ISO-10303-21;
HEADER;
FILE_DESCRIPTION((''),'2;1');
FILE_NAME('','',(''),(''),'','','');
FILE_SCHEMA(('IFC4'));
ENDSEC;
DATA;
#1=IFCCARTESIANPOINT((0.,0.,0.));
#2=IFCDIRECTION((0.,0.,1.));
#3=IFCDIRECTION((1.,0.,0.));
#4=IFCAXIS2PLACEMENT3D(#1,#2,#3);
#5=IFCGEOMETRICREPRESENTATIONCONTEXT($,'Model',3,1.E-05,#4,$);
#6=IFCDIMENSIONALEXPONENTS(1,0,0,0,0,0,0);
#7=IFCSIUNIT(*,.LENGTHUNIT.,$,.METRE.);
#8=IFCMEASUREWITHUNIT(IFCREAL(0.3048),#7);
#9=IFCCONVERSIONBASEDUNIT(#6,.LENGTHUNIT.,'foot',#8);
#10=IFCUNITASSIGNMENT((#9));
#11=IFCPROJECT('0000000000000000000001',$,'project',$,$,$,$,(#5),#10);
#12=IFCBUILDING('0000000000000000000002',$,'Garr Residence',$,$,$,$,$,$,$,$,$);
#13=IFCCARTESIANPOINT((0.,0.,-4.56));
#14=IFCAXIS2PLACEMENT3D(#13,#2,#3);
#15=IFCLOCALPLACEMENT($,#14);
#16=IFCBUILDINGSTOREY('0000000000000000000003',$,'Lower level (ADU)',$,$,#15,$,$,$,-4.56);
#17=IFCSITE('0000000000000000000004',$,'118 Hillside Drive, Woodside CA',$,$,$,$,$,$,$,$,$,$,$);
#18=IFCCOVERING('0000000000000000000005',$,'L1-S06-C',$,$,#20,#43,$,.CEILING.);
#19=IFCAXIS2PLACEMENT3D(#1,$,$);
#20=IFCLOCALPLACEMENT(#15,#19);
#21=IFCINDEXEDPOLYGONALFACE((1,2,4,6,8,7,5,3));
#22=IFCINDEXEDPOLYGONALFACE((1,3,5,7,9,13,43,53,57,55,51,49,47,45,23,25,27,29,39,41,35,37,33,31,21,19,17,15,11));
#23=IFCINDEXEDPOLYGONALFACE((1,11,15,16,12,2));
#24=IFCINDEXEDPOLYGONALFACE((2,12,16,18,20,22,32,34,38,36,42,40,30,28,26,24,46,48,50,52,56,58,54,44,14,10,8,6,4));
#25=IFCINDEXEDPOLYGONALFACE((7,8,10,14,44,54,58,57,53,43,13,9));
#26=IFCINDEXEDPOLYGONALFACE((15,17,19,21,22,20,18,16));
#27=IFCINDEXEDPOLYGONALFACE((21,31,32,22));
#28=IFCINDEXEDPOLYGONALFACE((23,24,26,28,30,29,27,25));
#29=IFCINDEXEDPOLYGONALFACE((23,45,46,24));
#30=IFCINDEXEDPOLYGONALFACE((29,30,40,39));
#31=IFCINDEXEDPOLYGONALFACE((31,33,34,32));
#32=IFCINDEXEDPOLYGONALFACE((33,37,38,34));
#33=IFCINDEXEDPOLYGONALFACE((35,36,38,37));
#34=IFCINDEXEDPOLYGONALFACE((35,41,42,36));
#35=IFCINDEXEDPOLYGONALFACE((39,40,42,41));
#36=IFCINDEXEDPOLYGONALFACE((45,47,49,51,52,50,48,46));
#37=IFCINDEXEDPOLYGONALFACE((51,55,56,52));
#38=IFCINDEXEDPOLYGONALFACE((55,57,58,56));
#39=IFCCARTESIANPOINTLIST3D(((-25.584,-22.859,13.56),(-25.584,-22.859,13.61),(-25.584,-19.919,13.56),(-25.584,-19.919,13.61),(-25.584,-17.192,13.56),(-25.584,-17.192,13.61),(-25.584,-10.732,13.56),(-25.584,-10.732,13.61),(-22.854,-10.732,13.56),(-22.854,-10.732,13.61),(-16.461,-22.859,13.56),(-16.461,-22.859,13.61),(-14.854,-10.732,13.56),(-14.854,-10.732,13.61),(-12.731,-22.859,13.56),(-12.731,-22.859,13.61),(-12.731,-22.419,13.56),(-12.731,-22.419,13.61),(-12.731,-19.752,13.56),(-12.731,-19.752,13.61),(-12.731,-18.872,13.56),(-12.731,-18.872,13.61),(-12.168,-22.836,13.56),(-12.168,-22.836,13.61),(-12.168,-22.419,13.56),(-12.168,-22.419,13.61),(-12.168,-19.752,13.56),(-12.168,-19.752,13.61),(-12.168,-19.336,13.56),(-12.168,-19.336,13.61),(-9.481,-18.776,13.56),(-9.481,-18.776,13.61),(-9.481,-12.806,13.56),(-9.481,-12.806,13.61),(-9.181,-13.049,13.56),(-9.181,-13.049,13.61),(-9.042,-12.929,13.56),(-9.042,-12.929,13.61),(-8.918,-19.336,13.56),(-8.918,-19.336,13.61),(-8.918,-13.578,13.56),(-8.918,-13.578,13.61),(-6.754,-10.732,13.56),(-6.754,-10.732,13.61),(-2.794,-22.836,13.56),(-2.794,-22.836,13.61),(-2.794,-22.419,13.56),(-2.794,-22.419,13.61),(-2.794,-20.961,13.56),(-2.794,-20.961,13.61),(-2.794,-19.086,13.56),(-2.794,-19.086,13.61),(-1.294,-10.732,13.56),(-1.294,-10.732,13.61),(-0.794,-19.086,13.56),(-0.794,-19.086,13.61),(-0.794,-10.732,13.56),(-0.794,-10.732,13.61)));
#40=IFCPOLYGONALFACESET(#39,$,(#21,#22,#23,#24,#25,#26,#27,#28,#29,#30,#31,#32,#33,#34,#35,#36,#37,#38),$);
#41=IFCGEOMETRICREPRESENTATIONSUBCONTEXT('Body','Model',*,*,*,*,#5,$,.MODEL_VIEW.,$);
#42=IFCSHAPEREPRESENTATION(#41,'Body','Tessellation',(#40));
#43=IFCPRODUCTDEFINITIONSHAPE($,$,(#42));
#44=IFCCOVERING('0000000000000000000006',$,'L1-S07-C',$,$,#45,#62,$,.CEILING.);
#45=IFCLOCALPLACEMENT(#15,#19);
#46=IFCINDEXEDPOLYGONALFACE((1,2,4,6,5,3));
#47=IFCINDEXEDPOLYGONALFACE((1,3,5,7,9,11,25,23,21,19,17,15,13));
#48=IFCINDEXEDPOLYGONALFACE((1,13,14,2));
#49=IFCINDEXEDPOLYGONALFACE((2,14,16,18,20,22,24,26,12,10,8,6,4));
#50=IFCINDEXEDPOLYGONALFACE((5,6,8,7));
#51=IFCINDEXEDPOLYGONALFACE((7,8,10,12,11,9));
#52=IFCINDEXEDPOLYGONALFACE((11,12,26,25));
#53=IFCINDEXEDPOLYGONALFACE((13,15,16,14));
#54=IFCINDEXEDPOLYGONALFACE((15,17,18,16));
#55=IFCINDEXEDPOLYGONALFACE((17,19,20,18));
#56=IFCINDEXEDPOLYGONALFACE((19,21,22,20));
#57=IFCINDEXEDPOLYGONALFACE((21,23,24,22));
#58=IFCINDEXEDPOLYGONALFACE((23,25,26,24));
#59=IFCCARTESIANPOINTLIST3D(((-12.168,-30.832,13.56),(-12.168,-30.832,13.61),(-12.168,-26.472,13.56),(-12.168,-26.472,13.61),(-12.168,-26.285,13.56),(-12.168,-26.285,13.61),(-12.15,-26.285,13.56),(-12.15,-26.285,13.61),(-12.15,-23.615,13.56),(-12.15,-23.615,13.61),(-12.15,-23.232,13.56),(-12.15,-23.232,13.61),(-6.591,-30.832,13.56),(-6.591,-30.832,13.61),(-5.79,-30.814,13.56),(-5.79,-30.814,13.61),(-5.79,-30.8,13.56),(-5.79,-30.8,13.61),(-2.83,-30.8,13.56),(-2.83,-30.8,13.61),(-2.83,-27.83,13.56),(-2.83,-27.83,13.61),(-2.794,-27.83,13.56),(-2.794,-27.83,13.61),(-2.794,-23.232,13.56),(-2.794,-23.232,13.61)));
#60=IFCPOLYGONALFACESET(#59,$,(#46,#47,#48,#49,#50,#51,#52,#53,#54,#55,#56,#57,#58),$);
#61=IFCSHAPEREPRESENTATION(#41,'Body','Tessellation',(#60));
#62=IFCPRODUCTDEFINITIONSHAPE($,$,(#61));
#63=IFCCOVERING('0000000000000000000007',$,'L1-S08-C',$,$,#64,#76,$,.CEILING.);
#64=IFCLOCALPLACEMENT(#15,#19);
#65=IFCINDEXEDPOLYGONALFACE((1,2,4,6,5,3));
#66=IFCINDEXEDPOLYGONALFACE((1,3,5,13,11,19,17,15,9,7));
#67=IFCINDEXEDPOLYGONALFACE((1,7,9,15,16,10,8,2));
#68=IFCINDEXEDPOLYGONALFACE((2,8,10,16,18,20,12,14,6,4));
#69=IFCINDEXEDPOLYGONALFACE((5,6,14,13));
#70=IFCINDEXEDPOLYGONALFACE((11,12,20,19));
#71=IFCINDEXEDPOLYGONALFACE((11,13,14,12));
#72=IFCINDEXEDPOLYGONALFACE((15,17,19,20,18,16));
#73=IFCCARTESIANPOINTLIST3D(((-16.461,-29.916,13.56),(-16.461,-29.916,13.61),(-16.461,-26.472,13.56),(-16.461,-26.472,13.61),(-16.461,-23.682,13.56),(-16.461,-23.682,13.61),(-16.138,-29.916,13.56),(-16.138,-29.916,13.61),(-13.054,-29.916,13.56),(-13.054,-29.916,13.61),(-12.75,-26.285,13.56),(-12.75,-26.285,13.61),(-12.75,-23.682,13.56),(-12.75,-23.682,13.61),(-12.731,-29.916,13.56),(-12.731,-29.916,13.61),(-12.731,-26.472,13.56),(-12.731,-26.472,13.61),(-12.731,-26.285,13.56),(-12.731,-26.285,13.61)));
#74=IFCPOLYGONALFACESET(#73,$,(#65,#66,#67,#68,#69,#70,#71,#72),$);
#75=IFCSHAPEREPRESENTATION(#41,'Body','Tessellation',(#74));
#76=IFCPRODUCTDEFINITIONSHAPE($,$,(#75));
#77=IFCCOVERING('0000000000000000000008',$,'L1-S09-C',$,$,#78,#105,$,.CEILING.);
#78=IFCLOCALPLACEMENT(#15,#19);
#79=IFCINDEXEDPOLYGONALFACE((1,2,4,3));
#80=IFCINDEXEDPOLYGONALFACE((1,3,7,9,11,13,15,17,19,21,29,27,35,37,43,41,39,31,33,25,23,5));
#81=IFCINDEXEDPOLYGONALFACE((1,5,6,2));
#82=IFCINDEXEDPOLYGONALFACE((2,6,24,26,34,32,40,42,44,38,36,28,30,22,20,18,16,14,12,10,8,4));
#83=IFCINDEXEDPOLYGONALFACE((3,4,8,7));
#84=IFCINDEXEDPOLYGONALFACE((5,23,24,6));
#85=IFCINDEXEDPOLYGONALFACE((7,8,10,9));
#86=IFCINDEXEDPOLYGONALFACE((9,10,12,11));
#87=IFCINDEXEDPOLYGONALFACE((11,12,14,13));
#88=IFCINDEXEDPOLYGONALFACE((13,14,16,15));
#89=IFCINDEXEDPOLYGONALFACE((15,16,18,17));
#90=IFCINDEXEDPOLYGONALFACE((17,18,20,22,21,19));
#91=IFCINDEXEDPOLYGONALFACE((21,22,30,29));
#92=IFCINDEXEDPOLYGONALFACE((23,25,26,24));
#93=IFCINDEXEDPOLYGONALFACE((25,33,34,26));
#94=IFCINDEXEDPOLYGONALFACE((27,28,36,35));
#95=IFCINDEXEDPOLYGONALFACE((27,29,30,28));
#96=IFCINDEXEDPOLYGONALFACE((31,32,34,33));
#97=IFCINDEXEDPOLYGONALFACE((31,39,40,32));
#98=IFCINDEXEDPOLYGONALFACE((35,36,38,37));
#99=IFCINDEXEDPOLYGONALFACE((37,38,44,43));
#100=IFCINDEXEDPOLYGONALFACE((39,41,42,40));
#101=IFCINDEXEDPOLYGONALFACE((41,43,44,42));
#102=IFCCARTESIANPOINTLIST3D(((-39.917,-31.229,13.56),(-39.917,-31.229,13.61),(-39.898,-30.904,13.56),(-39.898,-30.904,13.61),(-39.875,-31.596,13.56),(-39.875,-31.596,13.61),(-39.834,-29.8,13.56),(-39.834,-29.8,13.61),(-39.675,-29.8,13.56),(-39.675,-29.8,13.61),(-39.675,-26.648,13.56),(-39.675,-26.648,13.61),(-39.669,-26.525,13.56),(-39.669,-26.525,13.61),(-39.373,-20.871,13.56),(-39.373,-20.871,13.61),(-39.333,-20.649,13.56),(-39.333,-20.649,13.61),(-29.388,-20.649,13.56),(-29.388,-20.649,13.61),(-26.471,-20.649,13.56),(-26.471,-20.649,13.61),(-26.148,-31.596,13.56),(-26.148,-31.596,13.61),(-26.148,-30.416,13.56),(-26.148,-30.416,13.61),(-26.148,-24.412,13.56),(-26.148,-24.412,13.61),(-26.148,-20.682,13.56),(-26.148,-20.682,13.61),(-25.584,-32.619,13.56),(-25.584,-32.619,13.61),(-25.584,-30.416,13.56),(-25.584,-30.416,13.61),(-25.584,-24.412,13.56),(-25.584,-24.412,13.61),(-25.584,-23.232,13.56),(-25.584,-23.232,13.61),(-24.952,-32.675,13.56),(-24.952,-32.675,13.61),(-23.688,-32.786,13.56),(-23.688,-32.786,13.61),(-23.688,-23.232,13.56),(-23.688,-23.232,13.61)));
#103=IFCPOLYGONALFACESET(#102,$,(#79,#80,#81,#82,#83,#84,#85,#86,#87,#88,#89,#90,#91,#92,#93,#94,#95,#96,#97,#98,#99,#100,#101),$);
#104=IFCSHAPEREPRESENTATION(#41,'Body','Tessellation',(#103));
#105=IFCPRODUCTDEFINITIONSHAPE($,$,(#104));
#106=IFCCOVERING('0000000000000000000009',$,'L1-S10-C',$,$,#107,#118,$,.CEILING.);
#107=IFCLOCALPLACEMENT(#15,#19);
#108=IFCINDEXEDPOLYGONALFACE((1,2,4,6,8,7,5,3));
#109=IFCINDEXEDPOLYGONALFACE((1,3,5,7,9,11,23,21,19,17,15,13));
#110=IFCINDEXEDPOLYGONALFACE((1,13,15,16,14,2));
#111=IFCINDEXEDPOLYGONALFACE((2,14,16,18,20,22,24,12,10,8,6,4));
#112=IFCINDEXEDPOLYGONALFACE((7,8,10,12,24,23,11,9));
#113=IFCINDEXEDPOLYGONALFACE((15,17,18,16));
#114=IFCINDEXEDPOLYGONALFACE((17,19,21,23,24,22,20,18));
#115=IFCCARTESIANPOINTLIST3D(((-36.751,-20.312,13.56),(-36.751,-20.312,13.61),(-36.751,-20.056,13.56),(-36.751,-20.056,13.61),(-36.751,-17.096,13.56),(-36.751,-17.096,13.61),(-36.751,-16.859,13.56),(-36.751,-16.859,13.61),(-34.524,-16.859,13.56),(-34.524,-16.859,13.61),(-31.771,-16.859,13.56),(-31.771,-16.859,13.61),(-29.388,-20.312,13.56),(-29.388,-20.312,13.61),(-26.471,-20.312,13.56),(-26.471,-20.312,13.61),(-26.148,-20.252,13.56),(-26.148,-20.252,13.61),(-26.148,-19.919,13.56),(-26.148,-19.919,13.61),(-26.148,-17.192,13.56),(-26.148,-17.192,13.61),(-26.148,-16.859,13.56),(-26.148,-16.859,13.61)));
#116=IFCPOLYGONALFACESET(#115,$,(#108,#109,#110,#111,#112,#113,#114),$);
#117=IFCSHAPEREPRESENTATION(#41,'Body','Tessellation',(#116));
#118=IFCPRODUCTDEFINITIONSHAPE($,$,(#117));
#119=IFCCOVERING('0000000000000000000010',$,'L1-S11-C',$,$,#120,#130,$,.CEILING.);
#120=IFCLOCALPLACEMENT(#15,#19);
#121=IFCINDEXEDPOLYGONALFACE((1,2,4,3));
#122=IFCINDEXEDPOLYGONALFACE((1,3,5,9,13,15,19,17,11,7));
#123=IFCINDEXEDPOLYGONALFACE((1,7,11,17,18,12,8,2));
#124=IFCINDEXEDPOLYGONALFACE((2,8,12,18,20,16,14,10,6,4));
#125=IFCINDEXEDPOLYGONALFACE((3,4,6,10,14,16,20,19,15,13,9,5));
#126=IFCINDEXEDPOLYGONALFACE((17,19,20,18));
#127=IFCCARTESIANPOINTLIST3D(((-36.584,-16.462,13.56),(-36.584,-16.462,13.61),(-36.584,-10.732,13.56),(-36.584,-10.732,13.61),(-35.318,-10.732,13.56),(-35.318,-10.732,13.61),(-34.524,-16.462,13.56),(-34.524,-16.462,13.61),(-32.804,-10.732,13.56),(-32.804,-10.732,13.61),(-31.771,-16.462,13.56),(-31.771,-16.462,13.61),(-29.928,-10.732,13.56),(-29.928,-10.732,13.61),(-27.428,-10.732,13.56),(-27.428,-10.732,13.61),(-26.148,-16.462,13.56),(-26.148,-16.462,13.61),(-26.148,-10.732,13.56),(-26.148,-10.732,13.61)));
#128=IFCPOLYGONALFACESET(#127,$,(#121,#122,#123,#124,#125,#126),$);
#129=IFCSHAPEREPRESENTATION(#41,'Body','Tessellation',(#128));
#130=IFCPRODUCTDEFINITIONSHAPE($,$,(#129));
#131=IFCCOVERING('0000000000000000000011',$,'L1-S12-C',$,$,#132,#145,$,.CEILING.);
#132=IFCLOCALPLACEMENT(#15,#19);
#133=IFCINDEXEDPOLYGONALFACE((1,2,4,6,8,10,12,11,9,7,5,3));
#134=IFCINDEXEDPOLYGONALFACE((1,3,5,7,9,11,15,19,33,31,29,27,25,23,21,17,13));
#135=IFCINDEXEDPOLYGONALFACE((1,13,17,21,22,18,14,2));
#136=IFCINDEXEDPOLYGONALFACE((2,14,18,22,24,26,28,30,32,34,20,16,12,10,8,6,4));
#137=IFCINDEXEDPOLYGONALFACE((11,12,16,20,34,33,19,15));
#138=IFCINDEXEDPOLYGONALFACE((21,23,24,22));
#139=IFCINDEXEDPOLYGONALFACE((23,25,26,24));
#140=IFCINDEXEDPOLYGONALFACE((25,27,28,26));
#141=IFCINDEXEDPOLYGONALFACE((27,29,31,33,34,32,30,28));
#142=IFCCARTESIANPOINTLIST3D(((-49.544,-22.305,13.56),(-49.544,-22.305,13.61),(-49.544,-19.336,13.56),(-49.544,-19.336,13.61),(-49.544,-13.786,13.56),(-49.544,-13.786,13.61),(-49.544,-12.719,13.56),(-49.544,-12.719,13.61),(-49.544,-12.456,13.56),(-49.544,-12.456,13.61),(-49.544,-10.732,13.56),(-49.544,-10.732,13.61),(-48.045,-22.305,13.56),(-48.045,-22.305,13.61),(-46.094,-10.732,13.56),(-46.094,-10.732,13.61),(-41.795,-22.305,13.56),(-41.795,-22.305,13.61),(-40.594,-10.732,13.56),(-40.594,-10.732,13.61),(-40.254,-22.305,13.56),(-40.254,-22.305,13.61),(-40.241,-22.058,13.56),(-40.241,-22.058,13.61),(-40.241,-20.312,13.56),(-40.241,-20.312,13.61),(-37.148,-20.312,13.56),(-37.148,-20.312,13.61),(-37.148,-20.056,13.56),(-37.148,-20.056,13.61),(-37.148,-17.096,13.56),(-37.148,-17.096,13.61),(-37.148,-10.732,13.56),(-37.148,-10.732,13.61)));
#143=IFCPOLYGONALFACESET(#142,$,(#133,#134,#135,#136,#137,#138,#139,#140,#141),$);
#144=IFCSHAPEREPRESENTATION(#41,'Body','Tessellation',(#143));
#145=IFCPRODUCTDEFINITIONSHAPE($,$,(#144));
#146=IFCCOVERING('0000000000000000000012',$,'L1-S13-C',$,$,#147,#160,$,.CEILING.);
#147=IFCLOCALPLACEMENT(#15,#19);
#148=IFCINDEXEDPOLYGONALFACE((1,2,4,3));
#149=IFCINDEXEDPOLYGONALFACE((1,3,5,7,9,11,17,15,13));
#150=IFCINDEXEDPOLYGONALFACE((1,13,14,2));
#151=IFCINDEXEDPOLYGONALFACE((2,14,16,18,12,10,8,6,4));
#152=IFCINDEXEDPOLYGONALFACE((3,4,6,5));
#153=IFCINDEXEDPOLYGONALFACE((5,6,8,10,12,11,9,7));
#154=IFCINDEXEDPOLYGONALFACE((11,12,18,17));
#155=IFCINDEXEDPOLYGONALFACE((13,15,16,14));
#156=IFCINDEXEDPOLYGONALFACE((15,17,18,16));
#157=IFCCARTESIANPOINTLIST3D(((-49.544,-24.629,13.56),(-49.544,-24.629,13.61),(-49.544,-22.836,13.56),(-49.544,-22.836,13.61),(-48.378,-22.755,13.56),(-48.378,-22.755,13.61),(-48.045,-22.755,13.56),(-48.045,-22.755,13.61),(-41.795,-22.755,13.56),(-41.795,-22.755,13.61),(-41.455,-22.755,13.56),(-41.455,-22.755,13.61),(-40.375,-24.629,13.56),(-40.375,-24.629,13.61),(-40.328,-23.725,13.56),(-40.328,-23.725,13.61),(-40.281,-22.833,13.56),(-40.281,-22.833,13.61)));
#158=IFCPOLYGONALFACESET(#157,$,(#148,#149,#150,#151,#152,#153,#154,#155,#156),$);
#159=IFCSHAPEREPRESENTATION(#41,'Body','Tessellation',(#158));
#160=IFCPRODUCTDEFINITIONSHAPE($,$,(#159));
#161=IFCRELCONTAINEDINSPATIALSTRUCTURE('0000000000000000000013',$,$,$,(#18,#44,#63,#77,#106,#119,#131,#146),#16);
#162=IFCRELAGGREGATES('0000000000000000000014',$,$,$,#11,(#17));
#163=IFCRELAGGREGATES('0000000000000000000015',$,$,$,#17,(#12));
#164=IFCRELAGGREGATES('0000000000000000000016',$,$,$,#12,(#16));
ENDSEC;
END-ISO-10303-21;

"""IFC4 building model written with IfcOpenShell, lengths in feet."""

from ifc_helpers import new_model, entity, si_unit, converted_unit, frame, origin, origin_with_axes, place, context, subcontext, project, spatial, polyline, outline, extrude, element, save


model = new_model("IFC4")

# Units and contexts
model_context = context("Model", 3, precision=1e-05, world=origin_with_axes())
body_context = subcontext(model_context, "Body", "Model", "MODEL_VIEW")
ifc_project = project(units=[converted_unit("LENGTHUNIT", "foot", entity("IfcReal", 0.3048), si_unit("LENGTHUNIT", "METRE"), dimensions=[1, 0, 0, 0, 0, 0, 0])], contexts=[model_context])

# Site, building, storey
site = spatial("IfcSite", under=ifc_project, Name="118 Hillside Drive, Woodside CA")
building = spatial("IfcBuilding", under=site, Name="Garr Residence")
storey_placement = place(None, frame((0.0, 0.0, -4.56), z_axis=(0.0, 0.0, 1.0), x_axis=(1.0, 0.0, 0.0)))
storey = spatial("IfcBuildingStorey", under=building, at=storey_placement, Name="Lower level (ADU)", Elevation=-4.56)

# Coverings
covering_1_placement = place(storey_placement, frame((0.0, 0.0, 13.56), z_axis=(0.0, 0.0, 1.0), x_axis=(1.0, 0.0, 0.0)))
element("IfcCovering", 1, at=covering_1_placement, inside=storey, Name="L1-S06-C", PredefinedType="CEILING", context=body_context, shape_type="SweptSolid", body=[
    extrude(outline(polyline([(-22.854, -10.732), (-14.854, -10.732), (-6.754, -10.732), (-1.294, -10.732), (-0.794, -10.732), (-0.794, -19.086), (-2.794, -19.086), (-2.794, -19.086), (-2.794, -20.961), (-2.794, -22.419), (-2.794, -22.836), (-12.168, -22.836), (-12.168, -22.419), (-12.168, -19.752), (-12.168, -19.336), (-8.918, -19.336), (-8.918, -13.578), (-8.918, -13.578), (-9.181, -13.049), (-9.042, -12.929), (-9.481, -12.806), (-9.481, -18.776), (-12.731, -18.872), (-12.731, -19.752), (-12.731, -22.419), (-12.731, -22.859), (-16.461, -22.859), (-25.584, -22.859), (-25.584, -19.919), (-25.584, -17.192), (-25.584, -10.732), (-22.854, -10.732)])), origin(), (0.0, 0.0, 1.0), 0.05),
])
covering_2_placement = place(storey_placement, frame((0.0, 0.0, 13.56), z_axis=(0.0, 0.0, 1.0), x_axis=(1.0, 0.0, 0.0)))
element("IfcCovering", 2, at=covering_2_placement, inside=storey, Name="L1-S07-C", PredefinedType="CEILING", context=body_context, shape_type="SweptSolid", body=[
    extrude(outline(polyline([(-12.15, -23.615), (-12.15, -23.232), (-2.794, -23.232), (-2.794, -27.83), (-2.83, -27.83), (-2.83, -30.8), (-5.79, -30.8), (-5.79, -30.814), (-6.591, -30.832), (-12.168, -30.832), (-12.168, -26.472), (-12.168, -26.285), (-12.15, -26.285), (-12.15, -23.615)])), origin(), (0.0, 0.0, 1.0), 0.05),
])
covering_3_placement = place(storey_placement, frame((0.0, 0.0, 13.56), z_axis=(0.0, 0.0, 1.0), x_axis=(1.0, 0.0, 0.0)))
element("IfcCovering", 3, at=covering_3_placement, inside=storey, Name="L1-S08-C", PredefinedType="CEILING", context=body_context, shape_type="SweptSolid", body=[
    extrude(outline(polyline([(-12.731, -26.285), (-12.731, -26.472), (-12.731, -29.916), (-13.054, -29.916), (-16.138, -29.916), (-16.461, -29.916), (-16.461, -26.472), (-16.461, -23.682), (-12.75, -23.682), (-12.75, -26.285), (-12.731, -26.285)])), origin(), (0.0, 0.0, 1.0), 0.05),
])
covering_4_placement = place(storey_placement, frame((0.0, 0.0, 13.56), z_axis=(0.0, 0.0, 1.0), x_axis=(1.0, 0.0, 0.0)))
element("IfcCovering", 4, at=covering_4_placement, inside=storey, Name="L1-S09-C", PredefinedType="CEILING", context=body_context, shape_type="SweptSolid", body=[
    extrude(outline(polyline([(-39.898, -30.904), (-39.834, -29.8), (-39.675, -29.8), (-39.675, -26.648), (-39.669, -26.525), (-39.373, -20.871), (-39.333, -20.649), (-29.388, -20.649), (-26.471, -20.649), (-26.148, -20.682), (-26.148, -24.412), (-25.584, -24.412), (-25.584, -23.232), (-23.688, -23.232), (-23.688, -32.786), (-24.952, -32.675), (-25.584, -32.619), (-25.584, -30.416), (-26.148, -30.416), (-26.148, -31.596), (-39.875, -31.596), (-39.917, -31.229), (-39.898, -30.904)])), origin(), (0.0, 0.0, 1.0), 0.05),
])
covering_5_placement = place(storey_placement, frame((0.0, 0.0, 13.56), z_axis=(0.0, 0.0, 1.0), x_axis=(1.0, 0.0, 0.0)))
element("IfcCovering", 5, at=covering_5_placement, inside=storey, Name="L1-S10-C", PredefinedType="CEILING", context=body_context, shape_type="SweptSolid", body=[
    extrude(outline(polyline([(-36.751, -20.056), (-36.751, -17.096), (-36.751, -16.859), (-34.524, -16.859), (-31.771, -16.859), (-26.148, -16.859), (-26.148, -17.192), (-26.148, -19.919), (-26.148, -20.252), (-26.471, -20.312), (-29.388, -20.312), (-36.751, -20.312), (-36.751, -20.056)])), origin(), (0.0, 0.0, 1.0), 0.05),
])
covering_6_placement = place(storey_placement, frame((0.0, 0.0, 13.56), z_axis=(0.0, 0.0, 1.0), x_axis=(1.0, 0.0, 0.0)))
element("IfcCovering", 6, at=covering_6_placement, inside=storey, Name="L1-S11-C", PredefinedType="CEILING", context=body_context, shape_type="SweptSolid", body=[
    extrude(outline(polyline([(-36.584, -10.732), (-35.318, -10.732), (-32.804, -10.732), (-29.928, -10.732), (-27.428, -10.732), (-26.148, -10.732), (-26.148, -16.462), (-31.771, -16.462), (-34.524, -16.462), (-36.584, -16.462), (-36.584, -10.732)])), origin(), (0.0, 0.0, 1.0), 0.05),
])
covering_7_placement = place(storey_placement, frame((0.0, 0.0, 13.56), z_axis=(0.0, 0.0, 1.0), x_axis=(1.0, 0.0, 0.0)))
element("IfcCovering", 7, at=covering_7_placement, inside=storey, Name="L1-S12-C", PredefinedType="CEILING", context=body_context, shape_type="SweptSolid", body=[
    extrude(outline(polyline([(-49.544, -19.336), (-49.544, -13.786), (-49.544, -12.719), (-49.544, -12.456), (-49.544, -10.732), (-46.094, -10.732), (-40.594, -10.732), (-37.148, -10.732), (-37.148, -17.096), (-37.148, -20.056), (-37.148, -20.312), (-40.241, -20.312), (-40.241, -22.058), (-40.254, -22.305), (-41.795, -22.305), (-48.045, -22.305), (-49.544, -22.305), (-49.544, -19.336)])), origin(), (0.0, 0.0, 1.0), 0.05),
])
covering_8_placement = place(storey_placement, frame((0.0, 0.0, 13.56), z_axis=(0.0, 0.0, 1.0), x_axis=(1.0, 0.0, 0.0)))
element("IfcCovering", 8, at=covering_8_placement, inside=storey, Name="L1-S13-C", PredefinedType="CEILING", context=body_context, shape_type="SweptSolid", body=[
    extrude(outline(polyline([(-48.045, -22.755), (-41.795, -22.755), (-41.455, -22.755), (-40.281, -22.833), (-40.328, -23.725), (-40.375, -24.629), (-49.544, -24.629), (-49.544, -22.836), (-48.378, -22.755), (-48.045, -22.755)])), origin(), (0.0, 0.0, 1.0), 0.05),
])

save(model, "model.ifc")
